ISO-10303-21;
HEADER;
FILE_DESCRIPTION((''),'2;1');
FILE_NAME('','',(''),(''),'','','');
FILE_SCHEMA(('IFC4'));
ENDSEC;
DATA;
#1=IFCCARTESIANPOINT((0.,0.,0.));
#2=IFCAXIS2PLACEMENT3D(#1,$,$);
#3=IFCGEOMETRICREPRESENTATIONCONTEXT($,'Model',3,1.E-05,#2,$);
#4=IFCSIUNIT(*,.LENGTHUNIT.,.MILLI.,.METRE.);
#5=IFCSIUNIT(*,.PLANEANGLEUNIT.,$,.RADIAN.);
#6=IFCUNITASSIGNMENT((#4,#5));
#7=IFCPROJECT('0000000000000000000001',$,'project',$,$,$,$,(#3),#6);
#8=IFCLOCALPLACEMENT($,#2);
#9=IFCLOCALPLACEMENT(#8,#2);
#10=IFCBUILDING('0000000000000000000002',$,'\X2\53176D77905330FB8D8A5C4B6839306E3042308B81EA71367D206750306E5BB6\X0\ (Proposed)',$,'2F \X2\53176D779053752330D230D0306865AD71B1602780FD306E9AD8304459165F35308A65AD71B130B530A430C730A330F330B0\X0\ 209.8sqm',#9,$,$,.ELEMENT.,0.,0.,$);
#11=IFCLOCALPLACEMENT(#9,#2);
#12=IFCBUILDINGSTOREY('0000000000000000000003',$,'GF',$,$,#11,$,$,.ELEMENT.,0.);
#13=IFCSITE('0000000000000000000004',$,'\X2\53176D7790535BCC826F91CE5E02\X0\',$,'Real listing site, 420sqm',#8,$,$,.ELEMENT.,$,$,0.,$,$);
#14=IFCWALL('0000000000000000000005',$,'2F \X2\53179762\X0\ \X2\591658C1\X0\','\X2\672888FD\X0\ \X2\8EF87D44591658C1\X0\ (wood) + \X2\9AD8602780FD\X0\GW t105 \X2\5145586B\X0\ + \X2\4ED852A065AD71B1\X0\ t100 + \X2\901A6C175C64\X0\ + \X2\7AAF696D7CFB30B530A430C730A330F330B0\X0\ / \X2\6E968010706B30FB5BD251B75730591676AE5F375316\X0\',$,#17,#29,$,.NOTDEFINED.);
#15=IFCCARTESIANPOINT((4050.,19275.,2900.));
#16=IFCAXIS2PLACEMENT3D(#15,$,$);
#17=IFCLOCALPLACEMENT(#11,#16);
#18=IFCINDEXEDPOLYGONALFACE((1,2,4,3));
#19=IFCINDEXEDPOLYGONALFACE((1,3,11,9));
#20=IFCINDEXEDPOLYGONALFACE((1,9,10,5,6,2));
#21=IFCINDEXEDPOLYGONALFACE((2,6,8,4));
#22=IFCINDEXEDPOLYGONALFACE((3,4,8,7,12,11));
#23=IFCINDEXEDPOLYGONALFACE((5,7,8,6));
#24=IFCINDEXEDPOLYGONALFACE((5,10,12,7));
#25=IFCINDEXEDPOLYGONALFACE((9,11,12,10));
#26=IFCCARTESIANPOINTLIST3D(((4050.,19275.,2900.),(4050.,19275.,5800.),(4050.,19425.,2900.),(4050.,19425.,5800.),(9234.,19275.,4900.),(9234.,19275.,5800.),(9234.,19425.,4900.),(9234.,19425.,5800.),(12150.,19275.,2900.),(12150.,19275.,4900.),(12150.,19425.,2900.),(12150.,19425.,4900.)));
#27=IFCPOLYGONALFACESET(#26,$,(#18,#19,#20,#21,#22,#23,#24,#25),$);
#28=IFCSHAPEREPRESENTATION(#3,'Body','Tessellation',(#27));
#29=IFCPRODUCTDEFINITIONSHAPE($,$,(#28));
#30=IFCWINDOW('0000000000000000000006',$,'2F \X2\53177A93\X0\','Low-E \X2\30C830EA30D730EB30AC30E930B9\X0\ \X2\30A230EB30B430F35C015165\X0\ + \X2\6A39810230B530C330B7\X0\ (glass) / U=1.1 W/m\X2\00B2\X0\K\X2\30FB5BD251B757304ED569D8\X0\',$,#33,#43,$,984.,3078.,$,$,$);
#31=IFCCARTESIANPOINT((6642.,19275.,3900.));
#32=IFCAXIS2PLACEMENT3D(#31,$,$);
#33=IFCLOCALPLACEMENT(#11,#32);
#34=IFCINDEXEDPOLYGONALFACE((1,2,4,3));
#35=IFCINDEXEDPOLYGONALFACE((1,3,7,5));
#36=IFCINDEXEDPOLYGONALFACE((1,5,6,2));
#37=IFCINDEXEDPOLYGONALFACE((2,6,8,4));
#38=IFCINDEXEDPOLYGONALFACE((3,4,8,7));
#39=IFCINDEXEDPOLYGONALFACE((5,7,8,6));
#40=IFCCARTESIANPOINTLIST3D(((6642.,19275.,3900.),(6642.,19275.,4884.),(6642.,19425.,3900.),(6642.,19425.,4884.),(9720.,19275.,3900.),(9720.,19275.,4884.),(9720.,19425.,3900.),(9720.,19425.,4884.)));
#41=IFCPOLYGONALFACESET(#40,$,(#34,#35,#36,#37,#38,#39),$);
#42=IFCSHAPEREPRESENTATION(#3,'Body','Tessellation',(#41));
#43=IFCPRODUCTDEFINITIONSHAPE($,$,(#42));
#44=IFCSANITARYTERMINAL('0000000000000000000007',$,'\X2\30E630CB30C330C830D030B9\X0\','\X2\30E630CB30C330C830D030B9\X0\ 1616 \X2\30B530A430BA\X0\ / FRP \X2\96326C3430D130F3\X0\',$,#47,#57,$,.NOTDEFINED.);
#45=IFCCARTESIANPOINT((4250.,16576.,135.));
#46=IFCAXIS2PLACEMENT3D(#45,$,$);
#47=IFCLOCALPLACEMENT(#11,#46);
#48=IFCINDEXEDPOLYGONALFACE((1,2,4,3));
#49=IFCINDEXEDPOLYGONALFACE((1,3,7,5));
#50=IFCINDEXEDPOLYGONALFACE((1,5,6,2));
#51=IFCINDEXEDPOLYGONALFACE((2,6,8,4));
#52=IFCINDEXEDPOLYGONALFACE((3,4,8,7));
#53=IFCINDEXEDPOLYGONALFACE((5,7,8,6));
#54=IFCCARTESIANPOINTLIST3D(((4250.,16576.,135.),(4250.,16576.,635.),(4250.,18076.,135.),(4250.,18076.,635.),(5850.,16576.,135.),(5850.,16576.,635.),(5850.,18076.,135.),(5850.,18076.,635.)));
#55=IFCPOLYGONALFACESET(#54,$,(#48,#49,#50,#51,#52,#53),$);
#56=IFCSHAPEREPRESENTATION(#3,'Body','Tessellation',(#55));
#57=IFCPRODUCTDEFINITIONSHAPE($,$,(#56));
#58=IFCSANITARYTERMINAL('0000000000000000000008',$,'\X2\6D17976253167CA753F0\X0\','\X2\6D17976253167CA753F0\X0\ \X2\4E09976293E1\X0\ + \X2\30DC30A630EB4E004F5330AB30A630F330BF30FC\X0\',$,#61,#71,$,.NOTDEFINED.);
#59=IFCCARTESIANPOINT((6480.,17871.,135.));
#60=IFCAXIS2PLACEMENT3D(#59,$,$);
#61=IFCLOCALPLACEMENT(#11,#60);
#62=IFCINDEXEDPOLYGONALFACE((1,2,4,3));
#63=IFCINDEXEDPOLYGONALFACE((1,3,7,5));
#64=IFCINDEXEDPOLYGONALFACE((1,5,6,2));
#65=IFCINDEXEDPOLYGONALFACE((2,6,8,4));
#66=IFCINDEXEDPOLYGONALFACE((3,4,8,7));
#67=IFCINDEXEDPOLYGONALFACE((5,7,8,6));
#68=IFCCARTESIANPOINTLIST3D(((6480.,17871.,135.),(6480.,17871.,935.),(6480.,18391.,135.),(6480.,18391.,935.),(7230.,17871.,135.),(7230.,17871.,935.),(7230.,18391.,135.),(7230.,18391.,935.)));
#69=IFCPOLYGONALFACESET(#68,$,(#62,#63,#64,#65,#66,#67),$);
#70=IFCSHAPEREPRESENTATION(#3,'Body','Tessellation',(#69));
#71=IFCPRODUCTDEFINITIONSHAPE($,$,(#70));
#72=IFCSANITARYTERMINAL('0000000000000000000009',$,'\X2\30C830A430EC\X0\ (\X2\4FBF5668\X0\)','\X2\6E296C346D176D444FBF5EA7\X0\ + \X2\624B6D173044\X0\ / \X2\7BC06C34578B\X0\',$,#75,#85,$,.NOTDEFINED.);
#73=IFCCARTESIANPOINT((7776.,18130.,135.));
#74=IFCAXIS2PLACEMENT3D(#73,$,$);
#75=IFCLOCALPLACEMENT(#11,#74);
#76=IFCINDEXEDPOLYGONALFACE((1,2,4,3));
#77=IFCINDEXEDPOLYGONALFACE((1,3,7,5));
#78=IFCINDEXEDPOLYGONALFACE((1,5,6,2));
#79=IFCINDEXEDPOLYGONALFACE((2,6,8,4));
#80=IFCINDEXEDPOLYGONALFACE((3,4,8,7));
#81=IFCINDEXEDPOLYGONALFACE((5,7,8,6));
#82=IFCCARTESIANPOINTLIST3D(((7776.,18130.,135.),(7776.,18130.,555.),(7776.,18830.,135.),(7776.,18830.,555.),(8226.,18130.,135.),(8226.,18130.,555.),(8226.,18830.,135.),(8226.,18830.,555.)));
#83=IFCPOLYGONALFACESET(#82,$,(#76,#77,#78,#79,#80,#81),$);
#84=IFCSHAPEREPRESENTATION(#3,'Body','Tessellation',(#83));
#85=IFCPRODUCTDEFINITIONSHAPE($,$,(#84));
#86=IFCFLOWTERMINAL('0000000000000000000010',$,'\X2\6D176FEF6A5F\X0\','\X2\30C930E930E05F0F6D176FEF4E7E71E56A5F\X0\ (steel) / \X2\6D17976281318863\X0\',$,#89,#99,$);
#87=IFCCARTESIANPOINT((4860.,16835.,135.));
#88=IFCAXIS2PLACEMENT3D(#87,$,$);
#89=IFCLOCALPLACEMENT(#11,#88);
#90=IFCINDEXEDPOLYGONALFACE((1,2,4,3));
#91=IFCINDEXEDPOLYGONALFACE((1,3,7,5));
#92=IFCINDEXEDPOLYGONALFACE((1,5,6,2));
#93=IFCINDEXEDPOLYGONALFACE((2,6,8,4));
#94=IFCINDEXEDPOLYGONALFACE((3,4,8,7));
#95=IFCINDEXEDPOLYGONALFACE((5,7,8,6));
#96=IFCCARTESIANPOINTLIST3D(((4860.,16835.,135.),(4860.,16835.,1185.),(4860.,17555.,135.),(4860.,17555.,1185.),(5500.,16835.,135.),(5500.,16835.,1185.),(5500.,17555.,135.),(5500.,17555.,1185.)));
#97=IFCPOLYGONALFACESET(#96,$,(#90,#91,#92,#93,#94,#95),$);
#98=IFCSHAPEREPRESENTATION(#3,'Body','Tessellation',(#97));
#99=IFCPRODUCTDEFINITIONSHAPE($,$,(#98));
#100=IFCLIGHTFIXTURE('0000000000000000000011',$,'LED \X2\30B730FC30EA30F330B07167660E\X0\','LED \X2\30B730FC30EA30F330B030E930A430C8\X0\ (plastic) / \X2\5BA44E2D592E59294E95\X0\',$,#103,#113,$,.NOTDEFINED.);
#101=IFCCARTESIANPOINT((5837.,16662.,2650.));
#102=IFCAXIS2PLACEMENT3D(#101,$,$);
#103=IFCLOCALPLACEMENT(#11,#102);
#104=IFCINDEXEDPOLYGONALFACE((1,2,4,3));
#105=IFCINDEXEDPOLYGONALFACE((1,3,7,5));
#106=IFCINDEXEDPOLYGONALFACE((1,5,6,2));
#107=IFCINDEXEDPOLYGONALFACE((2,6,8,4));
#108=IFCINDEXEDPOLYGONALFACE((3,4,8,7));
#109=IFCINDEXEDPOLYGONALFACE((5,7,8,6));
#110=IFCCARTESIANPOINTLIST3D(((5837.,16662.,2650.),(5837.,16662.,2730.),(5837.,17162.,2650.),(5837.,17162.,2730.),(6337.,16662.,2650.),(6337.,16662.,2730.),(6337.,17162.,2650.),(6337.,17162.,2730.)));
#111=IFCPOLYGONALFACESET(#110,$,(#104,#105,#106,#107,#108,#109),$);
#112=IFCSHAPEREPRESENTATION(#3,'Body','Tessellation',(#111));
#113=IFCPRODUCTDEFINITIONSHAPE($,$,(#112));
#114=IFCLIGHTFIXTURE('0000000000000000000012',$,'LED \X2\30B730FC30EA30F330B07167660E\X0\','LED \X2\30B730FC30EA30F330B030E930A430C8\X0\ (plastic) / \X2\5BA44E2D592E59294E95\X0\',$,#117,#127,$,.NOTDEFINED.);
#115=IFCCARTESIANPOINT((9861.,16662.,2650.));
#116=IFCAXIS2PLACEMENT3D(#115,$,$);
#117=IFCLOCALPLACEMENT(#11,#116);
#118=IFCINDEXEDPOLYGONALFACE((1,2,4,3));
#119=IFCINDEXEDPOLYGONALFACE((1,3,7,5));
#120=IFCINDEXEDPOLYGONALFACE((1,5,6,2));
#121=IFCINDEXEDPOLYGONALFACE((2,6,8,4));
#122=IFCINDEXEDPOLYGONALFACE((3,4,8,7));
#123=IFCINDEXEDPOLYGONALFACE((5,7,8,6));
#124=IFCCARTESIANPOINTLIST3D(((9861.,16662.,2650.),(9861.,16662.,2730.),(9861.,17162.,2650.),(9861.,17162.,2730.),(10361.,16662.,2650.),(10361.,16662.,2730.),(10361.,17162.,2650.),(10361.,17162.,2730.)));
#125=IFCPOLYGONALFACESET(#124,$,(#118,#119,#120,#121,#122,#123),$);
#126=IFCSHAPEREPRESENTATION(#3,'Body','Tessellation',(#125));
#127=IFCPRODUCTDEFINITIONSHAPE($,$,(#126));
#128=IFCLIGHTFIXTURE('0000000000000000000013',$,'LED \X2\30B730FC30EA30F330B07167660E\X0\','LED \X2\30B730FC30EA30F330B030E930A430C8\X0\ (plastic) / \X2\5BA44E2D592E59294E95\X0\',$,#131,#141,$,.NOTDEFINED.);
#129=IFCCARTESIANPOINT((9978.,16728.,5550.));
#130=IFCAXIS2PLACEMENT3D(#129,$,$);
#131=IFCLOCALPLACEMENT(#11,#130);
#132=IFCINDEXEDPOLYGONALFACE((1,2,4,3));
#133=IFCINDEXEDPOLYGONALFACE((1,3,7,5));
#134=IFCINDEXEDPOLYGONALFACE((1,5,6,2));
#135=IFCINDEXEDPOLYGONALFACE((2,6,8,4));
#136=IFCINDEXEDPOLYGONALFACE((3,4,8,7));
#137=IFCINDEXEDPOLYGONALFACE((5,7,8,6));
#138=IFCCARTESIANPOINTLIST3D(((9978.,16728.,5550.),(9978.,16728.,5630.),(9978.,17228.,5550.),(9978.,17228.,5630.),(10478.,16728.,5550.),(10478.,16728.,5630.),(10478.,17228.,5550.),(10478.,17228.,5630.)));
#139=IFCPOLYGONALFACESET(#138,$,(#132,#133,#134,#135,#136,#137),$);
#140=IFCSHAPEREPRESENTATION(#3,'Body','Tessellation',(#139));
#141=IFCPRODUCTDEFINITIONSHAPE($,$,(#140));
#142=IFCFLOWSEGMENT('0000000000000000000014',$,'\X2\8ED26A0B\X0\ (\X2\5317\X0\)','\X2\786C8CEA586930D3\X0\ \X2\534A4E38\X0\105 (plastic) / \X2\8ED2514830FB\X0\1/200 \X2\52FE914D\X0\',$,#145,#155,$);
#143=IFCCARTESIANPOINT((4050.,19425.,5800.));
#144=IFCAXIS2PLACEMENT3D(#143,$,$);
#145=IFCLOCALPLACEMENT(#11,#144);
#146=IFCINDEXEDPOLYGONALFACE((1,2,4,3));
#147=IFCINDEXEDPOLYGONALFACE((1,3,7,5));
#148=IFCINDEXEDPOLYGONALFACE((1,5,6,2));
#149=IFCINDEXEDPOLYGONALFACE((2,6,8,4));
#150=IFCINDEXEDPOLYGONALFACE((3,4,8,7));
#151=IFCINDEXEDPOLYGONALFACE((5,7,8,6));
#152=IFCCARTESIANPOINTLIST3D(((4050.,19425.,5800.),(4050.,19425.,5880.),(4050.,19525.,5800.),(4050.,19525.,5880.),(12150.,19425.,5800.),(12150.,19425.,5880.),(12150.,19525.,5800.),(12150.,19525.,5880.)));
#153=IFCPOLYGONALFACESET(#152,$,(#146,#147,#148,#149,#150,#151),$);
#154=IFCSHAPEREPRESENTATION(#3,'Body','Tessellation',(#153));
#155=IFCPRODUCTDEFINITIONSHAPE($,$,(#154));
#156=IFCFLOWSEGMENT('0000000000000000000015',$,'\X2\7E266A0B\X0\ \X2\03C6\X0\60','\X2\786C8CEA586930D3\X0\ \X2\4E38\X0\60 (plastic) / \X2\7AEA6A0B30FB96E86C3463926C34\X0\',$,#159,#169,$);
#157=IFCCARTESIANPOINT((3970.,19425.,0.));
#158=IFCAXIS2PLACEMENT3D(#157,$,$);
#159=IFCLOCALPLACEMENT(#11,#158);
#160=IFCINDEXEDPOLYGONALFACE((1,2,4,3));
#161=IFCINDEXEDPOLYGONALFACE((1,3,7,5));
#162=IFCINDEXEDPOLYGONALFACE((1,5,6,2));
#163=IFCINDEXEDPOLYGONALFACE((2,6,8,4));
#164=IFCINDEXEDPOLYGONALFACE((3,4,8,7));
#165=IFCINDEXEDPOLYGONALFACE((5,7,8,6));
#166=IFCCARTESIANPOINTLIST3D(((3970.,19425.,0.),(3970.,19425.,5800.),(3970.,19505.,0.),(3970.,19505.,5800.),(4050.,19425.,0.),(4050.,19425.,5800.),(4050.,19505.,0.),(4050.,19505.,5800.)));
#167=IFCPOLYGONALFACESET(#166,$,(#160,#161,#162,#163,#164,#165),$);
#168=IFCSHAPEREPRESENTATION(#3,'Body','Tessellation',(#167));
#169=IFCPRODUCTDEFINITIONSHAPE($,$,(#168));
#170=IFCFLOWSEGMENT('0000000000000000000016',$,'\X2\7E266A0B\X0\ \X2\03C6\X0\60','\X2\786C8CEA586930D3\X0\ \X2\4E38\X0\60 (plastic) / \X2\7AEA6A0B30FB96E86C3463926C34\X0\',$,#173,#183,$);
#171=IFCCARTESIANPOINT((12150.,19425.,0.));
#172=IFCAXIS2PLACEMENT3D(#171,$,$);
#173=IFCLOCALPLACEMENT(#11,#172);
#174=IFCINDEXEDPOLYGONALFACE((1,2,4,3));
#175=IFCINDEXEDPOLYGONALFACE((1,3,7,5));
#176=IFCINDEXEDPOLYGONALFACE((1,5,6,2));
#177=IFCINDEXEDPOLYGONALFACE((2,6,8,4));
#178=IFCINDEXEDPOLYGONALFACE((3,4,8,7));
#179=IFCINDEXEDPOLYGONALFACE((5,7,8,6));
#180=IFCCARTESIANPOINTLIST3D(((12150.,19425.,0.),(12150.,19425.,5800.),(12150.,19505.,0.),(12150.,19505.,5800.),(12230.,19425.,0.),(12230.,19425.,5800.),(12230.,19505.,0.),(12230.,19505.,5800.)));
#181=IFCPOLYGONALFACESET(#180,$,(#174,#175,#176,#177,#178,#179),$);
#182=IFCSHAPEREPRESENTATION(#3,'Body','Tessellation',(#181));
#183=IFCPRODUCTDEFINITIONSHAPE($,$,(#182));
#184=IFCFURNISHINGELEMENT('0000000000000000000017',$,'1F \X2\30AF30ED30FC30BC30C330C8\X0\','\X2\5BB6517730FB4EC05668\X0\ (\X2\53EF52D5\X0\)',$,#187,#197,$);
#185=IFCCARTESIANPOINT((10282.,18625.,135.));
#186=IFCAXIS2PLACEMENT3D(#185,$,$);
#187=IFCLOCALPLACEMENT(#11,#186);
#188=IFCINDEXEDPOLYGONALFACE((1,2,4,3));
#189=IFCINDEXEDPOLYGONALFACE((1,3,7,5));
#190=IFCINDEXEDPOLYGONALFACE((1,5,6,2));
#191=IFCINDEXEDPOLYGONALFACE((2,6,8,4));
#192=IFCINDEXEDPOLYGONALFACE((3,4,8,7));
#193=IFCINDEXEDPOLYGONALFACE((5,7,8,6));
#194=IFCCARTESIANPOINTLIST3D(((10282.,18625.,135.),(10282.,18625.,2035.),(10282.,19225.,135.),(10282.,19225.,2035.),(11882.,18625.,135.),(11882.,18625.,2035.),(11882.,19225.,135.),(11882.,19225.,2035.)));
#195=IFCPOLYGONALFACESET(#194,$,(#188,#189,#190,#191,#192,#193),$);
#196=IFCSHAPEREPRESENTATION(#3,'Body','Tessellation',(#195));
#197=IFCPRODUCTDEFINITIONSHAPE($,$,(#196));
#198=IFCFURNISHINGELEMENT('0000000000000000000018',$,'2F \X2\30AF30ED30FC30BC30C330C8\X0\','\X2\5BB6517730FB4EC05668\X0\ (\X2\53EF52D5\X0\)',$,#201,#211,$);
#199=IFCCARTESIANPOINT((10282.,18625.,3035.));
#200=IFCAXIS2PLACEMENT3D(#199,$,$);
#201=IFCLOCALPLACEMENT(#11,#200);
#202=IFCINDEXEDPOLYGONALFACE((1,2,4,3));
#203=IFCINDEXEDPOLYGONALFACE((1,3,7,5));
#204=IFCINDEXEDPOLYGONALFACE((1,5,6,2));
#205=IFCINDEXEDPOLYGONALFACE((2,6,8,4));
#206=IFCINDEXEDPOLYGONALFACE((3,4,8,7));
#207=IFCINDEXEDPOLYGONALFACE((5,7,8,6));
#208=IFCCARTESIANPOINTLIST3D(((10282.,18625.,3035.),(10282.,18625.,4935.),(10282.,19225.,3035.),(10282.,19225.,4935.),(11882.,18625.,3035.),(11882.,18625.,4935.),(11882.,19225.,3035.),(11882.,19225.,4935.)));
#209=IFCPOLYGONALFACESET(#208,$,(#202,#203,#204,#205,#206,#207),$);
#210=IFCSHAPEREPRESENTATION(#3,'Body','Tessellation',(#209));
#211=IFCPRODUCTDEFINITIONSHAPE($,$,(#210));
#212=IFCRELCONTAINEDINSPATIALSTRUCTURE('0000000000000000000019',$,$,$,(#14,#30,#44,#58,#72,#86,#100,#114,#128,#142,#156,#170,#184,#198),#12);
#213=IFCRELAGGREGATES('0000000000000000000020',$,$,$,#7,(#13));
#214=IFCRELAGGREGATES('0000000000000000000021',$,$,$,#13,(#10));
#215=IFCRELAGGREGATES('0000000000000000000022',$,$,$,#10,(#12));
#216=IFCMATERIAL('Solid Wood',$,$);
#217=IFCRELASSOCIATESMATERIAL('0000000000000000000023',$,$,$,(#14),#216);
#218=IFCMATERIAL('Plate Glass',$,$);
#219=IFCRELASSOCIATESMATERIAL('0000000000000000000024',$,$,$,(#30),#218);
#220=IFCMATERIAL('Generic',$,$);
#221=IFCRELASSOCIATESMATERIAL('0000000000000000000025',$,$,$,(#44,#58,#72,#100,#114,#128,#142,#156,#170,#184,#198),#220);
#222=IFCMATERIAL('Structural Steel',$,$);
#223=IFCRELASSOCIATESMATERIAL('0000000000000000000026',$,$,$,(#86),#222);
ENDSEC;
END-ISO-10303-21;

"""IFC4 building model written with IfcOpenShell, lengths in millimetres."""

from ifc_helpers import new_model, si_unit, frame, frame_2d, origin, place, context, project, spatial, rectangle, extrude, material, element, fill, save


model = new_model("IFC4")

# Units and contexts
model_context = context("Model", 3, precision=1e-05, world=origin())
ifc_project = project(units=[si_unit("LENGTHUNIT", "METRE", prefix="MILLI"), si_unit("PLANEANGLEUNIT", "RADIAN")], contexts=[model_context])

# Site, building, storey
site_placement = place(None, origin())
site = spatial("IfcSite", under=ifc_project, at=site_placement, Name="北海道富良野市", ObjectType="Real listing site, 420sqm", CompositionType="ELEMENT", RefElevation=0.0)
building_placement = place(site_placement, origin())
building = spatial("IfcBuilding", under=site, at=building_placement, Name="北海道・越屋根のある自然素材の家 (Proposed)", ObjectType="2F 北海道産ヒバと断熱性能の高い外張り断熱サイディング 209.8sqm", CompositionType="ELEMENT", ElevationOfRefHeight=0.0, ElevationOfTerrain=0.0)
storey_placement = place(building_placement, origin())
storey = spatial("IfcBuildingStorey", under=building, at=storey_placement, Name="GF", CompositionType="ELEMENT", Elevation=0.0)

# Shared definitions
ifc_material_1 = material(Name="Solid Wood")

# Shared definitions
ifc_material_2 = material(Name="Plate Glass")

# Wall, opening, window
wall_1_placement = place(storey_placement, frame((4050.0, 19275.0, 2900.0)))
wall_1 = element("IfcWall", 1, at=wall_1_placement, inside=storey, material=ifc_material_1, Name="2F 北面 外壁", Description="木製 軸組外壁 (wood) + 高性能GW t105 充填 + 付加断熱 t100 + 通気層 + 窯業系サイディング / 準耐火・寒冷地外皮強化", PredefinedType="NOTDEFINED", context=model_context, shape_type="SweptSolid", body=[
    extrude(rectangle(XDim=8100.0, YDim=150.0, at=frame_2d((4050.0, 75.0))), frame((4050.0, 19275.0, 2900.0)), (0.0, 0.0, 1.0), 2900.0),
])
opening_1_placement = place(storey_placement, frame((6642.0, 19275.0, 3900.0)))
opening_1 = element("IfcOpeningElement", 2, at=opening_1_placement, cuts=wall_1, PredefinedType="NOTDEFINED", context=model_context, shape_type="SweptSolid", body=[
    extrude(rectangle(XDim=3078.0, YDim=150.0, at=frame_2d((1539.0, 75.0))), frame((6642.0, 19275.0, 3900.0)), (0.0, 0.0, 1.0), 984.0),
])
window_1_placement = place(storey_placement, frame((6642.0, 19275.0, 3900.0)))
window_1 = element("IfcWindow", 3, at=window_1_placement, inside=storey, material=ifc_material_2, Name="2F 北窓", Description="Low-E トリプルガラス アルゴン封入 + 樹脂サッシ (glass) / U=1.1 W/m²K・寒冷地仕様", OverallHeight=984.0, OverallWidth=3078.0, context=model_context, shape_type="SweptSolid", body=[
    extrude(rectangle(XDim=3078.0, YDim=150.0, at=frame_2d((1539.0, 75.0))), frame((6642.0, 19275.0, 3900.0)), (0.0, 0.0, 1.0), 984.0),
])
fill(opening_1, window_1)

# Sanitary terminals
ifc_material_3 = material(Name="Generic")
sanitary_terminal_1_placement = place(storey_placement, frame((4250.0, 16576.0, 135.0)))
element("IfcSanitaryTerminal", 4, at=sanitary_terminal_1_placement, inside=storey, material=ifc_material_3, Name="ユニットバス", Description="ユニットバス 1616 サイズ / FRP 防水パン", PredefinedType="NOTDEFINED", context=model_context, shape_type="SweptSolid", body=[
    extrude(rectangle(XDim=1600.0, YDim=1500.0, at=frame_2d((800.0, 750.0))), frame((4250.0, 16576.0, 135.0)), (0.0, 0.0, 1.0), 500.0),
])
sanitary_terminal_2_placement = place(storey_placement, frame((6480.0, 17871.0, 135.0)))
element("IfcSanitaryTerminal", 5, at=sanitary_terminal_2_placement, inside=storey, material=ifc_material_3, Name="洗面化粧台", Description="洗面化粧台 三面鏡 + ボウル一体カウンター", PredefinedType="NOTDEFINED", context=model_context, shape_type="SweptSolid", body=[
    extrude(rectangle(XDim=750.0, YDim=520.0, at=frame_2d((375.0, 260.0))), frame((6480.0, 17871.0, 135.0)), (0.0, 0.0, 1.0), 800.0),
])
sanitary_terminal_3_placement = place(storey_placement, frame((7776.0, 18130.0, 135.0)))
element("IfcSanitaryTerminal", 6, at=sanitary_terminal_3_placement, inside=storey, material=ifc_material_3, Name="トイレ (便器)", Description="温水洗浄便座 + 手洗い / 節水型", PredefinedType="NOTDEFINED", context=model_context, shape_type="SweptSolid", body=[
    extrude(rectangle(XDim=450.0, YDim=700.0, at=frame_2d((225.0, 350.0))), frame((7776.0, 18130.0, 135.0)), (0.0, 0.0, 1.0), 420.0),
])

# Flow terminal
ifc_material_4 = material(Name="Structural Steel")
flow_terminal_placement = place(storey_placement, frame((4860.0, 16835.0, 135.0)))
element("IfcFlowTerminal", 7, at=flow_terminal_placement, inside=storey, material=ifc_material_4, Name="洗濯機", Description="ドラム式洗濯乾燥機 (steel) / 洗面脱衣", context=model_context, shape_type="SweptSolid", body=[
    extrude(rectangle(XDim=640.0, YDim=720.0, at=frame_2d((320.0, 360.0))), frame((4860.0, 16835.0, 135.0)), (0.0, 0.0, 1.0), 1050.0),
])

# Light fixtures
light_fixture_1_placement = place(storey_placement, frame((5837.0, 16662.0, 2650.0)))
element("IfcLightFixture", 8, at=light_fixture_1_placement, inside=storey, material=ifc_material_3, Name="LED シーリング照明", Description="LED シーリングライト (plastic) / 室中央天井", PredefinedType="NOTDEFINED", context=model_context, shape_type="SweptSolid", body=[
    extrude(rectangle(XDim=500.0, YDim=500.0, at=frame_2d((250.0, 250.0))), frame((5837.0, 16662.0, 2650.0)), (0.0, 0.0, 1.0), 80.0),
])
light_fixture_2_placement = place(storey_placement, frame((9861.0, 16662.0, 2650.0)))
element("IfcLightFixture", 9, at=light_fixture_2_placement, inside=storey, material=ifc_material_3, Name="LED シーリング照明", Description="LED シーリングライト (plastic) / 室中央天井", PredefinedType="NOTDEFINED", context=model_context, shape_type="SweptSolid", body=[
    extrude(rectangle(XDim=500.0, YDim=500.0, at=frame_2d((250.0, 250.0))), frame((9861.0, 16662.0, 2650.0)), (0.0, 0.0, 1.0), 80.0),
])
light_fixture_3_placement = place(storey_placement, frame((9978.0, 16728.0, 5550.0)))
element("IfcLightFixture", 10, at=light_fixture_3_placement, inside=storey, material=ifc_material_3, Name="LED シーリング照明", Description="LED シーリングライト (plastic) / 室中央天井", PredefinedType="NOTDEFINED", context=model_context, shape_type="SweptSolid", body=[
    extrude(rectangle(XDim=500.0, YDim=500.0, at=frame_2d((250.0, 250.0))), frame((9978.0, 16728.0, 5550.0)), (0.0, 0.0, 1.0), 80.0),
])

# Flow segments
flow_segment_1_placement = place(storey_placement, frame((4050.0, 19425.0, 5800.0)))
element("IfcFlowSegment", 11, at=flow_segment_1_placement, inside=storey, material=ifc_material_3, Name="軒樋 (北)", Description="硬質塩ビ 半丸105 (plastic) / 軒先・1/200 勾配", context=model_context, shape_type="SweptSolid", body=[
    extrude(rectangle(XDim=8100.0, YDim=100.0, at=frame_2d((4050.0, 50.0))), frame((4050.0, 19425.0, 5800.0)), (0.0, 0.0, 1.0), 80.0),
])
flow_segment_2_placement = place(storey_placement, frame((3970.0, 19425.0, 0.0)))
element("IfcFlowSegment", 12, at=flow_segment_2_placement, inside=storey, material=ifc_material_3, Name="縦樋 φ60", Description="硬質塩ビ 丸60 (plastic) / 竪樋・雨水排水", context=model_context, shape_type="SweptSolid", body=[
    extrude(rectangle(XDim=80.0, YDim=80.0, at=frame_2d((40.0, 40.0))), frame((3970.0, 19425.0, 0.0)), (0.0, 0.0, 1.0), 5800.0),
])
flow_segment_3_placement = place(storey_placement, frame((12150.0, 19425.0, 0.0)))
element("IfcFlowSegment", 13, at=flow_segment_3_placement, inside=storey, material=ifc_material_3, Name="縦樋 φ60", Description="硬質塩ビ 丸60 (plastic) / 竪樋・雨水排水", context=model_context, shape_type="SweptSolid", body=[
    extrude(rectangle(XDim=80.0, YDim=80.0, at=frame_2d((40.0, 40.0))), frame((12150.0, 19425.0, 0.0)), (0.0, 0.0, 1.0), 5800.0),
])

# Furnishing elements
furnishing_1_placement = place(storey_placement, frame((10282.0, 18625.0, 135.0)))
element("IfcFurnishingElement", 14, at=furnishing_1_placement, inside=storey, material=ifc_material_3, Name="1F クローゼット", Description="家具・什器 (可動)", context=model_context, shape_type="SweptSolid", body=[
    extrude(rectangle(XDim=1600.0, YDim=600.0, at=frame_2d((800.0, 300.0))), frame((10282.0, 18625.0, 135.0)), (0.0, 0.0, 1.0), 1900.0),
])
furnishing_2_placement = place(storey_placement, frame((10282.0, 18625.0, 3035.0)))
element("IfcFurnishingElement", 15, at=furnishing_2_placement, inside=storey, material=ifc_material_3, Name="2F クローゼット", Description="家具・什器 (可動)", context=model_context, shape_type="SweptSolid", body=[
    extrude(rectangle(XDim=1600.0, YDim=600.0, at=frame_2d((800.0, 300.0))), frame((10282.0, 18625.0, 3035.0)), (0.0, 0.0, 1.0), 1900.0),
])

save(model, "model.ifc")
